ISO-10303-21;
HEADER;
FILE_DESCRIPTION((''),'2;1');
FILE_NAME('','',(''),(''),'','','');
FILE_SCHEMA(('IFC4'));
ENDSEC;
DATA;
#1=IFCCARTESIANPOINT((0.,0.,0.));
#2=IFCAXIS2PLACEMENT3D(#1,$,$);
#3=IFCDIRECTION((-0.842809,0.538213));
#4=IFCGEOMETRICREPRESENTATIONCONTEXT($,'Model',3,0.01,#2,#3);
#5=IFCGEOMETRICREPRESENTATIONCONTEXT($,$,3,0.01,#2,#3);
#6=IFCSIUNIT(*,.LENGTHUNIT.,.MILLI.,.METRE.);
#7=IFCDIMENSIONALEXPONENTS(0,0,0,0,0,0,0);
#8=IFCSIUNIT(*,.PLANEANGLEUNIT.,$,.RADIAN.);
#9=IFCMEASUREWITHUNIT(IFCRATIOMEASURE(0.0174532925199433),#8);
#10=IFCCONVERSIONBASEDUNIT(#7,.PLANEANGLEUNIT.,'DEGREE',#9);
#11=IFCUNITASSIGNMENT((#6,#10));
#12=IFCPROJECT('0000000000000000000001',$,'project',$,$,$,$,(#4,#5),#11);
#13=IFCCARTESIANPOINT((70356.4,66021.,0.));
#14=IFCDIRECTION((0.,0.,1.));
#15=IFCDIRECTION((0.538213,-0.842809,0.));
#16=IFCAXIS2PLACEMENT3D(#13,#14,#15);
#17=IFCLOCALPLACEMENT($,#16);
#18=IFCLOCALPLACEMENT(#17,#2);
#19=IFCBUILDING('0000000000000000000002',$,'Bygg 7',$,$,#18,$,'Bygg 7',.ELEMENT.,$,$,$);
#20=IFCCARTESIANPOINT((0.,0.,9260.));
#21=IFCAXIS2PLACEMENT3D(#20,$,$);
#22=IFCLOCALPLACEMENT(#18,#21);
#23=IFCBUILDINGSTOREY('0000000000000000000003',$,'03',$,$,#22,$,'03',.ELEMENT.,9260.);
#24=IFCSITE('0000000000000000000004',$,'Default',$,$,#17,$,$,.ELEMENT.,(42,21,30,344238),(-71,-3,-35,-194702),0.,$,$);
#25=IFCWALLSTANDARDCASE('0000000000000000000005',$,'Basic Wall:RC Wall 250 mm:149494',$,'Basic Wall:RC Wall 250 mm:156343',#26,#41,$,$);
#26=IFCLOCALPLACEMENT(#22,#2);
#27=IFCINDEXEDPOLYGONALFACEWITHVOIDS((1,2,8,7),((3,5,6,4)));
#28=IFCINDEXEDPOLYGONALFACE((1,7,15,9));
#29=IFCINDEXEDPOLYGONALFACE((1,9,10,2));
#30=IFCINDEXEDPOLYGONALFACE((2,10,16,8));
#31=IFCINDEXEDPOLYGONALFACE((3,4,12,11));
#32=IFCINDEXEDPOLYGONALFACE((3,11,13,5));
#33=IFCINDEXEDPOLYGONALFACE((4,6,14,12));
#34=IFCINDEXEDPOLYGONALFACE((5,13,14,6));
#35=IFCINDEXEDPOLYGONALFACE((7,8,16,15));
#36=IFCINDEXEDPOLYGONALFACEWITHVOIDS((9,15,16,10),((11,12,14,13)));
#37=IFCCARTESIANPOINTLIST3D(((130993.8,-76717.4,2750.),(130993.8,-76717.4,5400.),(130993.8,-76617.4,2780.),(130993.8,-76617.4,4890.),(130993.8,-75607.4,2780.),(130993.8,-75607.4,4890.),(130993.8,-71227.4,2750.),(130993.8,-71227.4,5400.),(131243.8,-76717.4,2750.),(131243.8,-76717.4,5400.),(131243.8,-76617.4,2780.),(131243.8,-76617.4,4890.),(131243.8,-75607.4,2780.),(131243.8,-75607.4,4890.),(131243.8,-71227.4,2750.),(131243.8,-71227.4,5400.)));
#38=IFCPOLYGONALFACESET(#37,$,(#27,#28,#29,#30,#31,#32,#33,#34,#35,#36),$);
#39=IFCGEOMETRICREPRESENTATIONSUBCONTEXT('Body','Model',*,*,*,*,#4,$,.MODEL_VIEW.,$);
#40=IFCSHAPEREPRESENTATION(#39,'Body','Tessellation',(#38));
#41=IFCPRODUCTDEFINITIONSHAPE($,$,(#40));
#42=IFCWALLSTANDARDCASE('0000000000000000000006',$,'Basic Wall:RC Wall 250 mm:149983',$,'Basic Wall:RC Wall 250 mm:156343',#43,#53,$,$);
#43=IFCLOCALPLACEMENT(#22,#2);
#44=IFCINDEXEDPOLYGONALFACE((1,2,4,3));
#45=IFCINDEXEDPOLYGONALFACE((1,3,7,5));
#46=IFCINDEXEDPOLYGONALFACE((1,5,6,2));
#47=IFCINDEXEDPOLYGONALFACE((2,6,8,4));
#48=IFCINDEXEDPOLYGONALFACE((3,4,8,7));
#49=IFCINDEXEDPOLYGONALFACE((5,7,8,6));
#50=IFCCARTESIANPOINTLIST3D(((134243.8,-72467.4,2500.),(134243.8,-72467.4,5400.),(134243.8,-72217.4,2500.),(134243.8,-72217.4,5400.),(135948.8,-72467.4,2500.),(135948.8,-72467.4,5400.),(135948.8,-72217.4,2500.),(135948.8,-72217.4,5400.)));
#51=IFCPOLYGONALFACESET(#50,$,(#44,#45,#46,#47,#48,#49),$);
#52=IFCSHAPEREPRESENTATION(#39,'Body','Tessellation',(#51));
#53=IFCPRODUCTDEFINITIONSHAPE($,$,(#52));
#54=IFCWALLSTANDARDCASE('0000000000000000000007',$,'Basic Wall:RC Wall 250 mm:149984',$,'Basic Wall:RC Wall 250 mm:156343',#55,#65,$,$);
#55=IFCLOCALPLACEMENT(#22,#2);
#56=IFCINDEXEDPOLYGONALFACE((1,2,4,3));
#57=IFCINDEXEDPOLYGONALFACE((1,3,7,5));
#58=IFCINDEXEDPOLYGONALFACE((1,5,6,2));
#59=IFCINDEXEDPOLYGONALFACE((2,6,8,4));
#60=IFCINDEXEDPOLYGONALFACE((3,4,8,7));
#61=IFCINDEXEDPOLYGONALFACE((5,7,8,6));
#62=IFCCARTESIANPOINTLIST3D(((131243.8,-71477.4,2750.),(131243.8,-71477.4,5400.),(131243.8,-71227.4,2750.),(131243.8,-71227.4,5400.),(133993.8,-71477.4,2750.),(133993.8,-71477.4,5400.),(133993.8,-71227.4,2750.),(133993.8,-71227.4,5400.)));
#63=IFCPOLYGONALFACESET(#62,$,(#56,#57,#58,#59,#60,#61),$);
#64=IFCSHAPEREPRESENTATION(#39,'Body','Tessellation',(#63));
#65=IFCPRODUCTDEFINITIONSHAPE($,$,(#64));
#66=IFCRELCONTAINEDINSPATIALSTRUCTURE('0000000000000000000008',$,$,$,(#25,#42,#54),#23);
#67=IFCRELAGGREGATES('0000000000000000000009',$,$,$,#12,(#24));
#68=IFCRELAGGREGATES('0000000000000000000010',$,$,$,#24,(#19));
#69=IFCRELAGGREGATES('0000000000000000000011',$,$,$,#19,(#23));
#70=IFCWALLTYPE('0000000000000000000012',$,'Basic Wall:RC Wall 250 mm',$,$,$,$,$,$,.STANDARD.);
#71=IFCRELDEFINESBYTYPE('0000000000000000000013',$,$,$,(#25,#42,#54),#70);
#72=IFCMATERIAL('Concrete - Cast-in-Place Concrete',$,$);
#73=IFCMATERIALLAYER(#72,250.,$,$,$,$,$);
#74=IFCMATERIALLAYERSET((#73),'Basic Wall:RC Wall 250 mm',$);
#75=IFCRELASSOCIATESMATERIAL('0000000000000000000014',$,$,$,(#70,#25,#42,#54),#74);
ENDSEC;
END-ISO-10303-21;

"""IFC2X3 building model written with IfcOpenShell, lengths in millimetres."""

from ifc_helpers import new_model, entity, si_unit, converted_unit, direction, frame, frame_2d, origin, origin_2d_with_axis, place, context, subcontext, project, spatial, polyline, rectangle, extrude, clip, bounded_halfspace, material, layer, layer_set, layer_usage, type_object, element, save


model = new_model("IFC2X3")

# Units and contexts
model_context = context("Model", 3, precision=0.01, world=origin(), true_north=direction((-0.842809, 0.538213)))
context_of_model = context(None, 3, precision=0.01, world=origin(), true_north=direction((-0.842809, 0.538213)))
body_context = subcontext(model_context, "Body", "Model", "MODEL_VIEW")
ifc_project = project(units=[si_unit("LENGTHUNIT", "METRE", prefix="MILLI"), converted_unit("PLANEANGLEUNIT", "DEGREE", entity("IfcRatioMeasure", 0.0174532925199433), si_unit("PLANEANGLEUNIT", "RADIAN"), dimensions=[0, 0, 0, 0, 0, 0, 0])], contexts=[model_context, context_of_model])

# Site, building, storey
site_placement = place(None, frame((70356.4, 66021.0, 0.0), z_axis=(0.0, 0.0, 1.0), x_axis=(0.538213, -0.842809, 0.0)))
site = spatial("IfcSite", under=ifc_project, at=site_placement, Name="Default", CompositionType="ELEMENT", RefLatitude=(42, 21, 30, 344238), RefLongitude=(-71, -3, -35, -194702), RefElevation=0.0)
building_placement = place(site_placement, origin())
building = spatial("IfcBuilding", under=site, at=building_placement, Name="Bygg 7", LongName="Bygg 7", CompositionType="ELEMENT")
storey_placement = place(building_placement, frame((0.0, 0.0, 9260.0)))
storey = spatial("IfcBuildingStorey", under=building, at=storey_placement, Name="03", LongName="03", CompositionType="ELEMENT", Elevation=9260.0)

# Shared definitions
ifc_material_1 = material(Name="Concrete - Cast-in-Place Concrete")

# Wall, opening
ifc_layer_1 = layer(ifc_material_1, 250.0)
ifc_layer_set_1 = layer_set([ifc_layer_1], Name="Basic Wall:RC Wall 250 mm")
wall_type_1 = type_object("IfcWallType", Name="Basic Wall:RC Wall 250 mm", PredefinedType="STANDARD", material=ifc_layer_set_1)
ifc_layer_usage_1 = layer_usage(ifc_layer_set_1, "AXIS2", "NEGATIVE", 125.0)
wall_1_placement = place(storey_placement, frame((131118.8, -76717.4, 2750.0), z_axis=(0.0, 0.0, 1.0), x_axis=(0.0, 1.0, 0.0)))
wall_1 = element("IfcWallStandardCase", 1, at=wall_1_placement, inside=storey, type_object=wall_type_1, material=ifc_layer_usage_1, Name="Basic Wall:RC Wall 250 mm:149494", ObjectType="Basic Wall:RC Wall 250 mm:156343", context=body_context, shape_type="Clipping", body=[
    clip(clip(extrude(rectangle(XDim=5490.0, YDim=250.0, at=frame_2d((2745.0, 0.0), x_axis=(-1.0, 0.0))), origin(), (0.0, 0.0, 1.0), 2650.0), bounded_halfspace(frame((0.0, -125.0, 2650.0), z_axis=(0.0, 0.0, -1.0), x_axis=(-0.99571, -0.092529, 0.0)), True, frame((0.0, -125.0, 2650.0)), polyline([(0.0, 0.0), (5240.1, 0.0), (5490.0, 0.0), (5490.0, 250.0), (0.0, 250.0), (0.0, 0.0)]))), bounded_halfspace(frame((5490.0, -125.0, 0.0), z_axis=(0.0, 0.0, 1.0), x_axis=(0.99571, 0.092529, 0.0)), True, frame((5490.0, -125.0, 0.0)), polyline([(0.0, 0.0), (0.0, 250.0), (-5490.0, 250.0), (-5490.0, 0.0), (-249.9, 0.0), (0.0, 0.0)]))),
])
opening_1_placement = place(wall_1_placement, origin())
element("IfcOpeningElement", 2, at=opening_1_placement, cuts=wall_1, ObjectType="Opening", context=body_context, shape_type="SweptSolid", body=[
    extrude(rectangle(XDim=2110.0, YDim=1010.0, at=origin_2d_with_axis()), frame((605.0, -125.0, 1085.0), z_axis=(0.0, 1.0, 0.0), x_axis=(0.0, 0.0, -1.0)), (0.0, 0.0, 1.0), 250.0),
])

# Walls
ifc_layer_usage_2 = layer_usage(ifc_layer_set_1, "AXIS2", "NEGATIVE", 125.0)
wall_2_placement = place(storey_placement, frame((134243.8, -72342.4, 2500.0)))
element("IfcWallStandardCase", 3, at=wall_2_placement, inside=storey, type_object=wall_type_1, material=ifc_layer_usage_2, Name="Basic Wall:RC Wall 250 mm:149983", ObjectType="Basic Wall:RC Wall 250 mm:156343", context=body_context, shape_type="SweptSolid", body=[
    extrude(rectangle(XDim=1705.0, YDim=250.0, at=frame_2d((852.5, 0.0), x_axis=(-1.0, 0.0))), origin(), (0.0, 0.0, 1.0), 2900.0),
])
ifc_layer_usage_3 = layer_usage(ifc_layer_set_1, "AXIS2", "NEGATIVE", 125.0)
wall_3_placement = place(storey_placement, frame((131243.8, -71352.4, 2750.0)))
element("IfcWallStandardCase", 4, at=wall_3_placement, inside=storey, type_object=wall_type_1, material=ifc_layer_usage_3, Name="Basic Wall:RC Wall 250 mm:149984", ObjectType="Basic Wall:RC Wall 250 mm:156343", context=body_context, shape_type="Clipping", body=[
    clip(clip(extrude(rectangle(XDim=2750.0, YDim=250.0, at=frame_2d((1375.0, 0.0), x_axis=(-1.0, 0.0))), origin(), (0.0, 0.0, 1.0), 2650.0), bounded_halfspace(frame((0.0, -125.0, 2650.0), z_axis=(0.0, 0.0, -1.0), x_axis=(0.092529, -0.99571, 0.0)), True, frame((0.0, -125.0, 2650.0)), polyline([(0.0, 0.0), (2750.0, 0.0), (2750.0, 250.0), (0.0, 250.0), (0.0, 0.0)]))), bounded_halfspace(frame((2750.0, -125.0, 0.0), z_axis=(0.0, 0.0, 1.0), x_axis=(-0.092529, 0.99571, 0.0)), True, frame((2750.0, -125.0, 0.0)), polyline([(0.0, 0.0), (0.0, 250.0), (-2750.0, 250.0), (-2750.0, 0.0), (0.0, 0.0)]))),
])

save(model, "model.ifc")
